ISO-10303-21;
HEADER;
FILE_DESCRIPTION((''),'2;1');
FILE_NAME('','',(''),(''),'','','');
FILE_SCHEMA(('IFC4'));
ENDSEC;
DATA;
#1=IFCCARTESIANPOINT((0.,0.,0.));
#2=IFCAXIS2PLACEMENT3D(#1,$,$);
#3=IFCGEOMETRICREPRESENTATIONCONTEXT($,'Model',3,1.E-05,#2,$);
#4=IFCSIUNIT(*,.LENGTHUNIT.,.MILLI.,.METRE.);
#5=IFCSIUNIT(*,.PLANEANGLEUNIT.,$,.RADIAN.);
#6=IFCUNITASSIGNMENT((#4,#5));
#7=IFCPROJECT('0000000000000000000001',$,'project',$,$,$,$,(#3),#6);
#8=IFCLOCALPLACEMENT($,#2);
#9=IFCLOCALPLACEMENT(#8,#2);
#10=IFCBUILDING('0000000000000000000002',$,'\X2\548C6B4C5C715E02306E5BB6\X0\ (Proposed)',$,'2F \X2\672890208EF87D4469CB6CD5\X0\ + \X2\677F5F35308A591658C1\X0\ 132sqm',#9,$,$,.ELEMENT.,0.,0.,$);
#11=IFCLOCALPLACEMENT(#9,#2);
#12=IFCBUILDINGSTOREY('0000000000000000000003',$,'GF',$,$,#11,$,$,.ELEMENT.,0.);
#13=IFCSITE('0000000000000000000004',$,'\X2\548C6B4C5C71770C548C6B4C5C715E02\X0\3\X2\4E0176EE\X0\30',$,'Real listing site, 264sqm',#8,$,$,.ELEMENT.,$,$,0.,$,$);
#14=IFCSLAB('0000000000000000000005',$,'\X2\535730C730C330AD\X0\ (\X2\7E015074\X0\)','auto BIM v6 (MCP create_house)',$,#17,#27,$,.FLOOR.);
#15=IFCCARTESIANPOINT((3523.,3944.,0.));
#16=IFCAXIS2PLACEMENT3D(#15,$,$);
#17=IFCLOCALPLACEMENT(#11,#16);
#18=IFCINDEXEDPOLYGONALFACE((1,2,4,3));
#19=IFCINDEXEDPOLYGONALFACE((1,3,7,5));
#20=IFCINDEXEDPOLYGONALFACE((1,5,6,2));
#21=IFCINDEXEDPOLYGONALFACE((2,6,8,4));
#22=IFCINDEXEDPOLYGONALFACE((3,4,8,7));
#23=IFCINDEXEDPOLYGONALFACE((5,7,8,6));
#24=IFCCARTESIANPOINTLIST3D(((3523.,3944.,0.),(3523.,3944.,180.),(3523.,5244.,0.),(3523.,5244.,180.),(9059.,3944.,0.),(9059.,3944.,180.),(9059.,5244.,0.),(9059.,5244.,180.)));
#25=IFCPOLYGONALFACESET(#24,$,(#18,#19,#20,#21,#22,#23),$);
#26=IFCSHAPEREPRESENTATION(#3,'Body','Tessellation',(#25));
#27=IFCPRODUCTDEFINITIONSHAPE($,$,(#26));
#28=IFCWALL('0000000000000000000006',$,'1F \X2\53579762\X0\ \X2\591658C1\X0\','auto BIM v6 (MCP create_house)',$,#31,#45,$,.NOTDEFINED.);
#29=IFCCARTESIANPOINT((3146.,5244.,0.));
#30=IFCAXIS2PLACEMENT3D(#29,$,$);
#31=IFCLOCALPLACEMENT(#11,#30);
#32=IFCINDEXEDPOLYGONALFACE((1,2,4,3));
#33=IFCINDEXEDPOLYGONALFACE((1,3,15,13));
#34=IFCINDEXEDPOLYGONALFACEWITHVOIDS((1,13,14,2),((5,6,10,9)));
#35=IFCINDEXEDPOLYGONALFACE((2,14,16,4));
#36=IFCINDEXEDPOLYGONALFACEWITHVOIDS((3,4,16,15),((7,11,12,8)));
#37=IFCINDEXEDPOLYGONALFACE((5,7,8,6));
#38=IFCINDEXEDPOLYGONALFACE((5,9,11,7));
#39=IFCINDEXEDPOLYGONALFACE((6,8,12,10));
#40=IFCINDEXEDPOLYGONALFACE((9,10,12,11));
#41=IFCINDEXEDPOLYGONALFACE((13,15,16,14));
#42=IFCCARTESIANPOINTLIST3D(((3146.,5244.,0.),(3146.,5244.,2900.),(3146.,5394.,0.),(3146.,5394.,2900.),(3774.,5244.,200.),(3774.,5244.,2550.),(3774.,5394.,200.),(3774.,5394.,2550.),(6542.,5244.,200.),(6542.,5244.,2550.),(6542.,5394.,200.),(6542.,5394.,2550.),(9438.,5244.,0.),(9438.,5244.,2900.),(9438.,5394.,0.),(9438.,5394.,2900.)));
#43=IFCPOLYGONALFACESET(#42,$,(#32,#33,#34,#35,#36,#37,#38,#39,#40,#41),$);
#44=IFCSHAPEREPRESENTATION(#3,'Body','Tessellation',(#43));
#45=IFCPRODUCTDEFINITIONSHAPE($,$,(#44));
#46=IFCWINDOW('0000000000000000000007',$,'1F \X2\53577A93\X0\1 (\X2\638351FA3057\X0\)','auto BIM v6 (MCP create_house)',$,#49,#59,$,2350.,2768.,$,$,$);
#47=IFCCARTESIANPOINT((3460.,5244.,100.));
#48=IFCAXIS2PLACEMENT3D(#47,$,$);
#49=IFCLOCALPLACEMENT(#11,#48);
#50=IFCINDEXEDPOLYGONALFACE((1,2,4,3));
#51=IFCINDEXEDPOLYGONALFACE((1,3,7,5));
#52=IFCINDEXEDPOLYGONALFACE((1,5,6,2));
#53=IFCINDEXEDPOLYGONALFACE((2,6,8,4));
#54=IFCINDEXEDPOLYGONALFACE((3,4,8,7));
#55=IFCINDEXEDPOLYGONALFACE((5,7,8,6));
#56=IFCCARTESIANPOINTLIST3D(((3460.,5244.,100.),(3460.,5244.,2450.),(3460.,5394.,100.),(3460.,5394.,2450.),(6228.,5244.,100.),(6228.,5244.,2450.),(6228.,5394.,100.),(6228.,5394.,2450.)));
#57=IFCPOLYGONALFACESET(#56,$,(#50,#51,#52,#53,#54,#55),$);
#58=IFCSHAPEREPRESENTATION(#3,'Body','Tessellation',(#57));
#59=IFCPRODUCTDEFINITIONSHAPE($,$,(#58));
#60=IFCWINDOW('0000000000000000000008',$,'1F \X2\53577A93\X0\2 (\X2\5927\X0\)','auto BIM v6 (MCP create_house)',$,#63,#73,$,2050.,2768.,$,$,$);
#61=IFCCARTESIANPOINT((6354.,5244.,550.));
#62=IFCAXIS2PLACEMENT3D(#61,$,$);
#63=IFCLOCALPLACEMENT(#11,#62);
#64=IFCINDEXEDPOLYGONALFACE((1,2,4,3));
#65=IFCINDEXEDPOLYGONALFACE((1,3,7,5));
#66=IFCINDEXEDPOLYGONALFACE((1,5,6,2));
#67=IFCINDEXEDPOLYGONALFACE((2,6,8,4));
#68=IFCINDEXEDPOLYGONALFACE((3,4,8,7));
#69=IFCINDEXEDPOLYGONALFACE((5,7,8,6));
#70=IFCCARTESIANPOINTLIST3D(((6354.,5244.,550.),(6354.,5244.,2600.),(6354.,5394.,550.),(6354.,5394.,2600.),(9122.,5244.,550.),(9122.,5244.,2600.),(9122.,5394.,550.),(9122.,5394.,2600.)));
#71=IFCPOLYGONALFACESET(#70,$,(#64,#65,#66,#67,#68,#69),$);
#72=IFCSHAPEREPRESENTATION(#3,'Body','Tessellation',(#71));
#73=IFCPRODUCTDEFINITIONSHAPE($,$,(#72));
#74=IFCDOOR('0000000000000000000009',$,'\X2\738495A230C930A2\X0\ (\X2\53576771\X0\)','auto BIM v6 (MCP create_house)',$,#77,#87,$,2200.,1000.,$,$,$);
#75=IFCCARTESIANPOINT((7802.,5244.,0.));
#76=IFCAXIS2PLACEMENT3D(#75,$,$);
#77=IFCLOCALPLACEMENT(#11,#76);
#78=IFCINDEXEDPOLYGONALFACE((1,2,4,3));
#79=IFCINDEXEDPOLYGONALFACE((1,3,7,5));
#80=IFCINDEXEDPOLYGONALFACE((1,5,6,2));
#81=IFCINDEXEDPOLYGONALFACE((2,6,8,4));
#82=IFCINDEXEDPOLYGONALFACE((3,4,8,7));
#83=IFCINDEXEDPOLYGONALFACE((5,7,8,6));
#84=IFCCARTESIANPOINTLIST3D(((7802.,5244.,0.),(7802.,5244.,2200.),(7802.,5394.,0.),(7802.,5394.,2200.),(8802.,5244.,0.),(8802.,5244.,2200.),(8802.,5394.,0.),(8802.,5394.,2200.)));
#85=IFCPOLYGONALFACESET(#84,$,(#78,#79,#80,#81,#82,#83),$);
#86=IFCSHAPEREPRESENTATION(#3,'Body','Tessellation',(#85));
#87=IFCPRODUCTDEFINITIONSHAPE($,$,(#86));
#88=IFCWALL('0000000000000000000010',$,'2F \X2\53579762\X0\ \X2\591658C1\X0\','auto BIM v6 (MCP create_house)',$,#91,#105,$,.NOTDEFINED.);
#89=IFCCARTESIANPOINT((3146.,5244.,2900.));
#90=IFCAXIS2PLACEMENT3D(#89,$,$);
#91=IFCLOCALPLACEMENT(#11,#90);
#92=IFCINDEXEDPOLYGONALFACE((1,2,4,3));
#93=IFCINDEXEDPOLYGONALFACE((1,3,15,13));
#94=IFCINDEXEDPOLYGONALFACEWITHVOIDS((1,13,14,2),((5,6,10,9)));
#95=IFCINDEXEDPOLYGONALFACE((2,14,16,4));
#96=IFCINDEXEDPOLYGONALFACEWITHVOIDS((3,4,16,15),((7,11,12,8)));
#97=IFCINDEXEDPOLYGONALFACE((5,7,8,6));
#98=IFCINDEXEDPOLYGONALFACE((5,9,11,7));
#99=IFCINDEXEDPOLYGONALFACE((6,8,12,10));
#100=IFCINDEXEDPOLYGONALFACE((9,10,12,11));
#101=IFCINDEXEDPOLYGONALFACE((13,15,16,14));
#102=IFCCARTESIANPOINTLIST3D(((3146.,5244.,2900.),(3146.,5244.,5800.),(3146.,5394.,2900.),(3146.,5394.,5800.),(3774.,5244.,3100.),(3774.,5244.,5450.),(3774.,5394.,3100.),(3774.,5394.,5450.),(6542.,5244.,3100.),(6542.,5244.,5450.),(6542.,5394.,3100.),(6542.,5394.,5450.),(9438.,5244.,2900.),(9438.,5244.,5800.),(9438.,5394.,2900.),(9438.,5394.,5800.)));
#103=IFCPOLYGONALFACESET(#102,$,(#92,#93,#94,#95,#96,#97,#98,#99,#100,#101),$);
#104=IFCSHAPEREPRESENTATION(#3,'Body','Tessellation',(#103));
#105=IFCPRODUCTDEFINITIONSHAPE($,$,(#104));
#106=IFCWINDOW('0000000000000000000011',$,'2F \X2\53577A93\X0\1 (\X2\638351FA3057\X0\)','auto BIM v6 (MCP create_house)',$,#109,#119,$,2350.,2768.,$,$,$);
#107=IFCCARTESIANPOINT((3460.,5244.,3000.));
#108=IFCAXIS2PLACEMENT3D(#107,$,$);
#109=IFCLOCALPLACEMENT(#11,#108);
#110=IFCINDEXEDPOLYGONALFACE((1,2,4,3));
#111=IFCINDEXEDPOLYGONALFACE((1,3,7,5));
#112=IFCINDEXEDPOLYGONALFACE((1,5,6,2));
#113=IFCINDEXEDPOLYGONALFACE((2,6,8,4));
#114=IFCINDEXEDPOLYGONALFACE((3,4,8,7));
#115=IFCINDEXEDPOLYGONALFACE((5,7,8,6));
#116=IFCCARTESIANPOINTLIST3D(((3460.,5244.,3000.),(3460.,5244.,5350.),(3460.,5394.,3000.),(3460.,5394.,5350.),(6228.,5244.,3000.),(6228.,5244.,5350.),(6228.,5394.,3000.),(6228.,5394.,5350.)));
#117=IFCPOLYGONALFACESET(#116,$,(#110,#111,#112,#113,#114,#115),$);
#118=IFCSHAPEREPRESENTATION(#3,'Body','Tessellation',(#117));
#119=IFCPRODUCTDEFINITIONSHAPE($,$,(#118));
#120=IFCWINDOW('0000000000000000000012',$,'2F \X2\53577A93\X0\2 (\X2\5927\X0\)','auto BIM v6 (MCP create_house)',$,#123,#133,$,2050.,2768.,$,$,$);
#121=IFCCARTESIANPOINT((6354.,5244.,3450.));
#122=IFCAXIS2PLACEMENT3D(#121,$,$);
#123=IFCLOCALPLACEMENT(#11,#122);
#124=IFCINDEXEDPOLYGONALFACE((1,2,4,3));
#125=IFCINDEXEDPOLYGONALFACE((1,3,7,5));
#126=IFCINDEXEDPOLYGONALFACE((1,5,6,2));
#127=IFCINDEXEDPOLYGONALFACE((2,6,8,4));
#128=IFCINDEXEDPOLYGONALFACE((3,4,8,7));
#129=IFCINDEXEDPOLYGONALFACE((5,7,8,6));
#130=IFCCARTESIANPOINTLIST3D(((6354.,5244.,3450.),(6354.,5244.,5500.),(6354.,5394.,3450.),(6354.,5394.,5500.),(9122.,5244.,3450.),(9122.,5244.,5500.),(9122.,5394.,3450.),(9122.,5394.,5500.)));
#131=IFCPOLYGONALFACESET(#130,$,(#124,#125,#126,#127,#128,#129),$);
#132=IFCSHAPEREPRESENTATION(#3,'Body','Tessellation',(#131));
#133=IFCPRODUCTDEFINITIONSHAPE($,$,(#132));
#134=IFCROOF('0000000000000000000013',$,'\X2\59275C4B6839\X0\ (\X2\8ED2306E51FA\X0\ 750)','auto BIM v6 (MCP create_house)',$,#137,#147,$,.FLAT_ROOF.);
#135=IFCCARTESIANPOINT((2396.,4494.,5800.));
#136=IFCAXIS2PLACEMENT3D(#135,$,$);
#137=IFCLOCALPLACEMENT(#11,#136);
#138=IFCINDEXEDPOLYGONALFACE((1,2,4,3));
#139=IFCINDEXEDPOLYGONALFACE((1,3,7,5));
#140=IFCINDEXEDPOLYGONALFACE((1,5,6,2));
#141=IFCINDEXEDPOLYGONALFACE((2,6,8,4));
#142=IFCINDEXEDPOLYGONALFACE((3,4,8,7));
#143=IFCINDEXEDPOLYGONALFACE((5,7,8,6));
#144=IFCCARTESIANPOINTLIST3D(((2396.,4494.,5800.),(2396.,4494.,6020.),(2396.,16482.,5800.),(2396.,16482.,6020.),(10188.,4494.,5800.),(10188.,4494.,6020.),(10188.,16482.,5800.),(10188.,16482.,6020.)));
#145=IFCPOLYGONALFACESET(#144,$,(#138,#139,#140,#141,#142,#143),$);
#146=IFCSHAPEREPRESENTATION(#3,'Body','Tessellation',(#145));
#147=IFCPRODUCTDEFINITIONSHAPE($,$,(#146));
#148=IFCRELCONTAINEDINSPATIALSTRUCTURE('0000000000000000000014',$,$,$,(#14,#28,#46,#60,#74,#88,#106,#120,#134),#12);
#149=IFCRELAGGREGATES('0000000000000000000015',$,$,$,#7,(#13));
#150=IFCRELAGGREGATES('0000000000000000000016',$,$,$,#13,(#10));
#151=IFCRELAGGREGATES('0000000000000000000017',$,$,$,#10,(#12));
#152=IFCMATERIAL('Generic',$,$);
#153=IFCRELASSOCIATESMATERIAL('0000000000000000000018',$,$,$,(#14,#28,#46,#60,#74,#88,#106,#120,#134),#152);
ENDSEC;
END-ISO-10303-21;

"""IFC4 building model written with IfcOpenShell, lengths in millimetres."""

from ifc_helpers import new_model, si_unit, frame, frame_2d, origin, place, context, project, spatial, rectangle, extrude, material, element, fill, save


model = new_model("IFC4")

# Units and contexts
model_context = context("Model", 3, precision=1e-05, world=origin())
ifc_project = project(units=[si_unit("LENGTHUNIT", "METRE", prefix="MILLI"), si_unit("PLANEANGLEUNIT", "RADIAN")], contexts=[model_context])

# Site, building, storey
site_placement = place(None, origin())
site = spatial("IfcSite", under=ifc_project, at=site_placement, Name="和歌山県和歌山市3丁目30", ObjectType="Real listing site, 264sqm", CompositionType="ELEMENT", RefElevation=0.0)
building_placement = place(site_placement, origin())
building = spatial("IfcBuilding", under=site, at=building_placement, Name="和歌山市の家 (Proposed)", ObjectType="2F 木造軸組構法 + 板張り外壁 132sqm", CompositionType="ELEMENT", ElevationOfRefHeight=0.0, ElevationOfTerrain=0.0)
storey_placement = place(building_placement, origin())
storey = spatial("IfcBuildingStorey", under=building, at=storey_placement, Name="GF", CompositionType="ELEMENT", Elevation=0.0)

# Slab
ifc_material = material(Name="Generic")
slab_1_placement = place(storey_placement, frame((3523.0, 3944.0, 0.0)))
element("IfcSlab", 1, at=slab_1_placement, inside=storey, material=ifc_material, Name="南デッキ (縁側)", Description="auto BIM v6 (MCP create_house)", PredefinedType="FLOOR", context=model_context, shape_type="SweptSolid", body=[
    extrude(rectangle(XDim=5536.0, YDim=1300.0, at=frame_2d((2768.0, 650.0))), frame((3523.0, 3944.0, 0.0)), (0.0, 0.0, 1.0), 180.0),
])

# Wall, openings, windows, door
wall_1_placement = place(storey_placement, frame((3146.0, 5244.0, 0.0)))
wall_1 = element("IfcWall", 2, at=wall_1_placement, inside=storey, material=ifc_material, Name="1F 南面 外壁", Description="auto BIM v6 (MCP create_house)", PredefinedType="NOTDEFINED", context=model_context, shape_type="SweptSolid", body=[
    extrude(rectangle(XDim=6292.0, YDim=150.0, at=frame_2d((3146.0, 75.0))), frame((3146.0, 5244.0, 0.0)), (0.0, 0.0, 1.0), 2900.0),
])
opening_1_placement = place(storey_placement, frame((3460.0, 5244.0, 100.0)))
opening_1 = element("IfcOpeningElement", 3, at=opening_1_placement, cuts=wall_1, PredefinedType="NOTDEFINED", context=model_context, shape_type="SweptSolid", body=[
    extrude(rectangle(XDim=2768.0, YDim=150.0, at=frame_2d((1384.0, 75.0))), frame((3460.0, 5244.0, 100.0)), (0.0, 0.0, 1.0), 2350.0),
])
opening_2_placement = place(storey_placement, frame((6354.0, 5244.0, 550.0)))
opening_2 = element("IfcOpeningElement", 4, at=opening_2_placement, cuts=wall_1, PredefinedType="NOTDEFINED", context=model_context, shape_type="SweptSolid", body=[
    extrude(rectangle(XDim=2768.0, YDim=150.0, at=frame_2d((1384.0, 75.0))), frame((6354.0, 5244.0, 550.0)), (0.0, 0.0, 1.0), 2050.0),
])
opening_3_placement = place(storey_placement, frame((7802.0, 5244.0, 0.0)))
opening_3 = element("IfcOpeningElement", 5, at=opening_3_placement, cuts=wall_1, PredefinedType="NOTDEFINED", context=model_context, shape_type="SweptSolid", body=[
    extrude(rectangle(XDim=1000.0, YDim=150.0, at=frame_2d((500.0, 75.0))), frame((7802.0, 5244.0, 0.0)), (0.0, 0.0, 1.0), 2200.0),
])
window_1_placement = place(storey_placement, frame((3460.0, 5244.0, 100.0)))
window_1 = element("IfcWindow", 6, at=window_1_placement, inside=storey, material=ifc_material, Name="1F 南窓1 (掃出し)", Description="auto BIM v6 (MCP create_house)", OverallHeight=2350.0, OverallWidth=2768.0, context=model_context, shape_type="SweptSolid", body=[
    extrude(rectangle(XDim=2768.0, YDim=150.0, at=frame_2d((1384.0, 75.0))), frame((3460.0, 5244.0, 100.0)), (0.0, 0.0, 1.0), 2350.0),
])
fill(opening_1, window_1)
window_2_placement = place(storey_placement, frame((6354.0, 5244.0, 550.0)))
window_2 = element("IfcWindow", 7, at=window_2_placement, inside=storey, material=ifc_material, Name="1F 南窓2 (大)", Description="auto BIM v6 (MCP create_house)", OverallHeight=2050.0, OverallWidth=2768.0, context=model_context, shape_type="SweptSolid", body=[
    extrude(rectangle(XDim=2768.0, YDim=150.0, at=frame_2d((1384.0, 75.0))), frame((6354.0, 5244.0, 550.0)), (0.0, 0.0, 1.0), 2050.0),
])
fill(opening_2, window_2)
door_placement = place(storey_placement, frame((7802.0, 5244.0, 0.0)))
door = element("IfcDoor", 8, at=door_placement, inside=storey, material=ifc_material, Name="玄関ドア (南東)", Description="auto BIM v6 (MCP create_house)", OverallHeight=2200.0, OverallWidth=1000.0, context=model_context, shape_type="SweptSolid", body=[
    extrude(rectangle(XDim=1000.0, YDim=150.0, at=frame_2d((500.0, 75.0))), frame((7802.0, 5244.0, 0.0)), (0.0, 0.0, 1.0), 2200.0),
])
fill(opening_3, door)

# Wall, openings, windows
wall_2_placement = place(storey_placement, frame((3146.0, 5244.0, 2900.0)))
wall_2 = element("IfcWall", 9, at=wall_2_placement, inside=storey, material=ifc_material, Name="2F 南面 外壁", Description="auto BIM v6 (MCP create_house)", PredefinedType="NOTDEFINED", context=model_context, shape_type="SweptSolid", body=[
    extrude(rectangle(XDim=6292.0, YDim=150.0, at=frame_2d((3146.0, 75.0))), frame((3146.0, 5244.0, 2900.0)), (0.0, 0.0, 1.0), 2900.0),
])
opening_4_placement = place(storey_placement, frame((3460.0, 5244.0, 3000.0)))
opening_4 = element("IfcOpeningElement", 10, at=opening_4_placement, cuts=wall_2, PredefinedType="NOTDEFINED", context=model_context, shape_type="SweptSolid", body=[
    extrude(rectangle(XDim=2768.0, YDim=150.0, at=frame_2d((1384.0, 75.0))), frame((3460.0, 5244.0, 3000.0)), (0.0, 0.0, 1.0), 2350.0),
])
opening_5_placement = place(storey_placement, frame((6354.0, 5244.0, 3450.0)))
opening_5 = element("IfcOpeningElement", 11, at=opening_5_placement, cuts=wall_2, PredefinedType="NOTDEFINED", context=model_context, shape_type="SweptSolid", body=[
    extrude(rectangle(XDim=2768.0, YDim=150.0, at=frame_2d((1384.0, 75.0))), frame((6354.0, 5244.0, 3450.0)), (0.0, 0.0, 1.0), 2050.0),
])
window_3_placement = place(storey_placement, frame((3460.0, 5244.0, 3000.0)))
window_3 = element("IfcWindow", 12, at=window_3_placement, inside=storey, material=ifc_material, Name="2F 南窓1 (掃出し)", Description="auto BIM v6 (MCP create_house)", OverallHeight=2350.0, OverallWidth=2768.0, context=model_context, shape_type="SweptSolid", body=[
    extrude(rectangle(XDim=2768.0, YDim=150.0, at=frame_2d((1384.0, 75.0))), frame((3460.0, 5244.0, 3000.0)), (0.0, 0.0, 1.0), 2350.0),
])
fill(opening_4, window_3)
window_4_placement = place(storey_placement, frame((6354.0, 5244.0, 3450.0)))
window_4 = element("IfcWindow", 13, at=window_4_placement, inside=storey, material=ifc_material, Name="2F 南窓2 (大)", Description="auto BIM v6 (MCP create_house)", OverallHeight=2050.0, OverallWidth=2768.0, context=model_context, shape_type="SweptSolid", body=[
    extrude(rectangle(XDim=2768.0, YDim=150.0, at=frame_2d((1384.0, 75.0))), frame((6354.0, 5244.0, 3450.0)), (0.0, 0.0, 1.0), 2050.0),
])
fill(opening_5, window_4)

# Roof
roof_placement = place(storey_placement, frame((2396.0, 4494.0, 5800.0)))
element("IfcRoof", 14, at=roof_placement, inside=storey, material=ifc_material, Name="大屋根 (軒の出 750)", Description="auto BIM v6 (MCP create_house)", PredefinedType="FLAT_ROOF", context=model_context, shape_type="SweptSolid", body=[
    extrude(rectangle(XDim=7792.0, YDim=11988.0, at=frame_2d((3896.0, 5994.0))), frame((2396.0, 4494.0, 5800.0)), (0.0, 0.0, 1.0), 220.0),
])

save(model, "model.ifc")
